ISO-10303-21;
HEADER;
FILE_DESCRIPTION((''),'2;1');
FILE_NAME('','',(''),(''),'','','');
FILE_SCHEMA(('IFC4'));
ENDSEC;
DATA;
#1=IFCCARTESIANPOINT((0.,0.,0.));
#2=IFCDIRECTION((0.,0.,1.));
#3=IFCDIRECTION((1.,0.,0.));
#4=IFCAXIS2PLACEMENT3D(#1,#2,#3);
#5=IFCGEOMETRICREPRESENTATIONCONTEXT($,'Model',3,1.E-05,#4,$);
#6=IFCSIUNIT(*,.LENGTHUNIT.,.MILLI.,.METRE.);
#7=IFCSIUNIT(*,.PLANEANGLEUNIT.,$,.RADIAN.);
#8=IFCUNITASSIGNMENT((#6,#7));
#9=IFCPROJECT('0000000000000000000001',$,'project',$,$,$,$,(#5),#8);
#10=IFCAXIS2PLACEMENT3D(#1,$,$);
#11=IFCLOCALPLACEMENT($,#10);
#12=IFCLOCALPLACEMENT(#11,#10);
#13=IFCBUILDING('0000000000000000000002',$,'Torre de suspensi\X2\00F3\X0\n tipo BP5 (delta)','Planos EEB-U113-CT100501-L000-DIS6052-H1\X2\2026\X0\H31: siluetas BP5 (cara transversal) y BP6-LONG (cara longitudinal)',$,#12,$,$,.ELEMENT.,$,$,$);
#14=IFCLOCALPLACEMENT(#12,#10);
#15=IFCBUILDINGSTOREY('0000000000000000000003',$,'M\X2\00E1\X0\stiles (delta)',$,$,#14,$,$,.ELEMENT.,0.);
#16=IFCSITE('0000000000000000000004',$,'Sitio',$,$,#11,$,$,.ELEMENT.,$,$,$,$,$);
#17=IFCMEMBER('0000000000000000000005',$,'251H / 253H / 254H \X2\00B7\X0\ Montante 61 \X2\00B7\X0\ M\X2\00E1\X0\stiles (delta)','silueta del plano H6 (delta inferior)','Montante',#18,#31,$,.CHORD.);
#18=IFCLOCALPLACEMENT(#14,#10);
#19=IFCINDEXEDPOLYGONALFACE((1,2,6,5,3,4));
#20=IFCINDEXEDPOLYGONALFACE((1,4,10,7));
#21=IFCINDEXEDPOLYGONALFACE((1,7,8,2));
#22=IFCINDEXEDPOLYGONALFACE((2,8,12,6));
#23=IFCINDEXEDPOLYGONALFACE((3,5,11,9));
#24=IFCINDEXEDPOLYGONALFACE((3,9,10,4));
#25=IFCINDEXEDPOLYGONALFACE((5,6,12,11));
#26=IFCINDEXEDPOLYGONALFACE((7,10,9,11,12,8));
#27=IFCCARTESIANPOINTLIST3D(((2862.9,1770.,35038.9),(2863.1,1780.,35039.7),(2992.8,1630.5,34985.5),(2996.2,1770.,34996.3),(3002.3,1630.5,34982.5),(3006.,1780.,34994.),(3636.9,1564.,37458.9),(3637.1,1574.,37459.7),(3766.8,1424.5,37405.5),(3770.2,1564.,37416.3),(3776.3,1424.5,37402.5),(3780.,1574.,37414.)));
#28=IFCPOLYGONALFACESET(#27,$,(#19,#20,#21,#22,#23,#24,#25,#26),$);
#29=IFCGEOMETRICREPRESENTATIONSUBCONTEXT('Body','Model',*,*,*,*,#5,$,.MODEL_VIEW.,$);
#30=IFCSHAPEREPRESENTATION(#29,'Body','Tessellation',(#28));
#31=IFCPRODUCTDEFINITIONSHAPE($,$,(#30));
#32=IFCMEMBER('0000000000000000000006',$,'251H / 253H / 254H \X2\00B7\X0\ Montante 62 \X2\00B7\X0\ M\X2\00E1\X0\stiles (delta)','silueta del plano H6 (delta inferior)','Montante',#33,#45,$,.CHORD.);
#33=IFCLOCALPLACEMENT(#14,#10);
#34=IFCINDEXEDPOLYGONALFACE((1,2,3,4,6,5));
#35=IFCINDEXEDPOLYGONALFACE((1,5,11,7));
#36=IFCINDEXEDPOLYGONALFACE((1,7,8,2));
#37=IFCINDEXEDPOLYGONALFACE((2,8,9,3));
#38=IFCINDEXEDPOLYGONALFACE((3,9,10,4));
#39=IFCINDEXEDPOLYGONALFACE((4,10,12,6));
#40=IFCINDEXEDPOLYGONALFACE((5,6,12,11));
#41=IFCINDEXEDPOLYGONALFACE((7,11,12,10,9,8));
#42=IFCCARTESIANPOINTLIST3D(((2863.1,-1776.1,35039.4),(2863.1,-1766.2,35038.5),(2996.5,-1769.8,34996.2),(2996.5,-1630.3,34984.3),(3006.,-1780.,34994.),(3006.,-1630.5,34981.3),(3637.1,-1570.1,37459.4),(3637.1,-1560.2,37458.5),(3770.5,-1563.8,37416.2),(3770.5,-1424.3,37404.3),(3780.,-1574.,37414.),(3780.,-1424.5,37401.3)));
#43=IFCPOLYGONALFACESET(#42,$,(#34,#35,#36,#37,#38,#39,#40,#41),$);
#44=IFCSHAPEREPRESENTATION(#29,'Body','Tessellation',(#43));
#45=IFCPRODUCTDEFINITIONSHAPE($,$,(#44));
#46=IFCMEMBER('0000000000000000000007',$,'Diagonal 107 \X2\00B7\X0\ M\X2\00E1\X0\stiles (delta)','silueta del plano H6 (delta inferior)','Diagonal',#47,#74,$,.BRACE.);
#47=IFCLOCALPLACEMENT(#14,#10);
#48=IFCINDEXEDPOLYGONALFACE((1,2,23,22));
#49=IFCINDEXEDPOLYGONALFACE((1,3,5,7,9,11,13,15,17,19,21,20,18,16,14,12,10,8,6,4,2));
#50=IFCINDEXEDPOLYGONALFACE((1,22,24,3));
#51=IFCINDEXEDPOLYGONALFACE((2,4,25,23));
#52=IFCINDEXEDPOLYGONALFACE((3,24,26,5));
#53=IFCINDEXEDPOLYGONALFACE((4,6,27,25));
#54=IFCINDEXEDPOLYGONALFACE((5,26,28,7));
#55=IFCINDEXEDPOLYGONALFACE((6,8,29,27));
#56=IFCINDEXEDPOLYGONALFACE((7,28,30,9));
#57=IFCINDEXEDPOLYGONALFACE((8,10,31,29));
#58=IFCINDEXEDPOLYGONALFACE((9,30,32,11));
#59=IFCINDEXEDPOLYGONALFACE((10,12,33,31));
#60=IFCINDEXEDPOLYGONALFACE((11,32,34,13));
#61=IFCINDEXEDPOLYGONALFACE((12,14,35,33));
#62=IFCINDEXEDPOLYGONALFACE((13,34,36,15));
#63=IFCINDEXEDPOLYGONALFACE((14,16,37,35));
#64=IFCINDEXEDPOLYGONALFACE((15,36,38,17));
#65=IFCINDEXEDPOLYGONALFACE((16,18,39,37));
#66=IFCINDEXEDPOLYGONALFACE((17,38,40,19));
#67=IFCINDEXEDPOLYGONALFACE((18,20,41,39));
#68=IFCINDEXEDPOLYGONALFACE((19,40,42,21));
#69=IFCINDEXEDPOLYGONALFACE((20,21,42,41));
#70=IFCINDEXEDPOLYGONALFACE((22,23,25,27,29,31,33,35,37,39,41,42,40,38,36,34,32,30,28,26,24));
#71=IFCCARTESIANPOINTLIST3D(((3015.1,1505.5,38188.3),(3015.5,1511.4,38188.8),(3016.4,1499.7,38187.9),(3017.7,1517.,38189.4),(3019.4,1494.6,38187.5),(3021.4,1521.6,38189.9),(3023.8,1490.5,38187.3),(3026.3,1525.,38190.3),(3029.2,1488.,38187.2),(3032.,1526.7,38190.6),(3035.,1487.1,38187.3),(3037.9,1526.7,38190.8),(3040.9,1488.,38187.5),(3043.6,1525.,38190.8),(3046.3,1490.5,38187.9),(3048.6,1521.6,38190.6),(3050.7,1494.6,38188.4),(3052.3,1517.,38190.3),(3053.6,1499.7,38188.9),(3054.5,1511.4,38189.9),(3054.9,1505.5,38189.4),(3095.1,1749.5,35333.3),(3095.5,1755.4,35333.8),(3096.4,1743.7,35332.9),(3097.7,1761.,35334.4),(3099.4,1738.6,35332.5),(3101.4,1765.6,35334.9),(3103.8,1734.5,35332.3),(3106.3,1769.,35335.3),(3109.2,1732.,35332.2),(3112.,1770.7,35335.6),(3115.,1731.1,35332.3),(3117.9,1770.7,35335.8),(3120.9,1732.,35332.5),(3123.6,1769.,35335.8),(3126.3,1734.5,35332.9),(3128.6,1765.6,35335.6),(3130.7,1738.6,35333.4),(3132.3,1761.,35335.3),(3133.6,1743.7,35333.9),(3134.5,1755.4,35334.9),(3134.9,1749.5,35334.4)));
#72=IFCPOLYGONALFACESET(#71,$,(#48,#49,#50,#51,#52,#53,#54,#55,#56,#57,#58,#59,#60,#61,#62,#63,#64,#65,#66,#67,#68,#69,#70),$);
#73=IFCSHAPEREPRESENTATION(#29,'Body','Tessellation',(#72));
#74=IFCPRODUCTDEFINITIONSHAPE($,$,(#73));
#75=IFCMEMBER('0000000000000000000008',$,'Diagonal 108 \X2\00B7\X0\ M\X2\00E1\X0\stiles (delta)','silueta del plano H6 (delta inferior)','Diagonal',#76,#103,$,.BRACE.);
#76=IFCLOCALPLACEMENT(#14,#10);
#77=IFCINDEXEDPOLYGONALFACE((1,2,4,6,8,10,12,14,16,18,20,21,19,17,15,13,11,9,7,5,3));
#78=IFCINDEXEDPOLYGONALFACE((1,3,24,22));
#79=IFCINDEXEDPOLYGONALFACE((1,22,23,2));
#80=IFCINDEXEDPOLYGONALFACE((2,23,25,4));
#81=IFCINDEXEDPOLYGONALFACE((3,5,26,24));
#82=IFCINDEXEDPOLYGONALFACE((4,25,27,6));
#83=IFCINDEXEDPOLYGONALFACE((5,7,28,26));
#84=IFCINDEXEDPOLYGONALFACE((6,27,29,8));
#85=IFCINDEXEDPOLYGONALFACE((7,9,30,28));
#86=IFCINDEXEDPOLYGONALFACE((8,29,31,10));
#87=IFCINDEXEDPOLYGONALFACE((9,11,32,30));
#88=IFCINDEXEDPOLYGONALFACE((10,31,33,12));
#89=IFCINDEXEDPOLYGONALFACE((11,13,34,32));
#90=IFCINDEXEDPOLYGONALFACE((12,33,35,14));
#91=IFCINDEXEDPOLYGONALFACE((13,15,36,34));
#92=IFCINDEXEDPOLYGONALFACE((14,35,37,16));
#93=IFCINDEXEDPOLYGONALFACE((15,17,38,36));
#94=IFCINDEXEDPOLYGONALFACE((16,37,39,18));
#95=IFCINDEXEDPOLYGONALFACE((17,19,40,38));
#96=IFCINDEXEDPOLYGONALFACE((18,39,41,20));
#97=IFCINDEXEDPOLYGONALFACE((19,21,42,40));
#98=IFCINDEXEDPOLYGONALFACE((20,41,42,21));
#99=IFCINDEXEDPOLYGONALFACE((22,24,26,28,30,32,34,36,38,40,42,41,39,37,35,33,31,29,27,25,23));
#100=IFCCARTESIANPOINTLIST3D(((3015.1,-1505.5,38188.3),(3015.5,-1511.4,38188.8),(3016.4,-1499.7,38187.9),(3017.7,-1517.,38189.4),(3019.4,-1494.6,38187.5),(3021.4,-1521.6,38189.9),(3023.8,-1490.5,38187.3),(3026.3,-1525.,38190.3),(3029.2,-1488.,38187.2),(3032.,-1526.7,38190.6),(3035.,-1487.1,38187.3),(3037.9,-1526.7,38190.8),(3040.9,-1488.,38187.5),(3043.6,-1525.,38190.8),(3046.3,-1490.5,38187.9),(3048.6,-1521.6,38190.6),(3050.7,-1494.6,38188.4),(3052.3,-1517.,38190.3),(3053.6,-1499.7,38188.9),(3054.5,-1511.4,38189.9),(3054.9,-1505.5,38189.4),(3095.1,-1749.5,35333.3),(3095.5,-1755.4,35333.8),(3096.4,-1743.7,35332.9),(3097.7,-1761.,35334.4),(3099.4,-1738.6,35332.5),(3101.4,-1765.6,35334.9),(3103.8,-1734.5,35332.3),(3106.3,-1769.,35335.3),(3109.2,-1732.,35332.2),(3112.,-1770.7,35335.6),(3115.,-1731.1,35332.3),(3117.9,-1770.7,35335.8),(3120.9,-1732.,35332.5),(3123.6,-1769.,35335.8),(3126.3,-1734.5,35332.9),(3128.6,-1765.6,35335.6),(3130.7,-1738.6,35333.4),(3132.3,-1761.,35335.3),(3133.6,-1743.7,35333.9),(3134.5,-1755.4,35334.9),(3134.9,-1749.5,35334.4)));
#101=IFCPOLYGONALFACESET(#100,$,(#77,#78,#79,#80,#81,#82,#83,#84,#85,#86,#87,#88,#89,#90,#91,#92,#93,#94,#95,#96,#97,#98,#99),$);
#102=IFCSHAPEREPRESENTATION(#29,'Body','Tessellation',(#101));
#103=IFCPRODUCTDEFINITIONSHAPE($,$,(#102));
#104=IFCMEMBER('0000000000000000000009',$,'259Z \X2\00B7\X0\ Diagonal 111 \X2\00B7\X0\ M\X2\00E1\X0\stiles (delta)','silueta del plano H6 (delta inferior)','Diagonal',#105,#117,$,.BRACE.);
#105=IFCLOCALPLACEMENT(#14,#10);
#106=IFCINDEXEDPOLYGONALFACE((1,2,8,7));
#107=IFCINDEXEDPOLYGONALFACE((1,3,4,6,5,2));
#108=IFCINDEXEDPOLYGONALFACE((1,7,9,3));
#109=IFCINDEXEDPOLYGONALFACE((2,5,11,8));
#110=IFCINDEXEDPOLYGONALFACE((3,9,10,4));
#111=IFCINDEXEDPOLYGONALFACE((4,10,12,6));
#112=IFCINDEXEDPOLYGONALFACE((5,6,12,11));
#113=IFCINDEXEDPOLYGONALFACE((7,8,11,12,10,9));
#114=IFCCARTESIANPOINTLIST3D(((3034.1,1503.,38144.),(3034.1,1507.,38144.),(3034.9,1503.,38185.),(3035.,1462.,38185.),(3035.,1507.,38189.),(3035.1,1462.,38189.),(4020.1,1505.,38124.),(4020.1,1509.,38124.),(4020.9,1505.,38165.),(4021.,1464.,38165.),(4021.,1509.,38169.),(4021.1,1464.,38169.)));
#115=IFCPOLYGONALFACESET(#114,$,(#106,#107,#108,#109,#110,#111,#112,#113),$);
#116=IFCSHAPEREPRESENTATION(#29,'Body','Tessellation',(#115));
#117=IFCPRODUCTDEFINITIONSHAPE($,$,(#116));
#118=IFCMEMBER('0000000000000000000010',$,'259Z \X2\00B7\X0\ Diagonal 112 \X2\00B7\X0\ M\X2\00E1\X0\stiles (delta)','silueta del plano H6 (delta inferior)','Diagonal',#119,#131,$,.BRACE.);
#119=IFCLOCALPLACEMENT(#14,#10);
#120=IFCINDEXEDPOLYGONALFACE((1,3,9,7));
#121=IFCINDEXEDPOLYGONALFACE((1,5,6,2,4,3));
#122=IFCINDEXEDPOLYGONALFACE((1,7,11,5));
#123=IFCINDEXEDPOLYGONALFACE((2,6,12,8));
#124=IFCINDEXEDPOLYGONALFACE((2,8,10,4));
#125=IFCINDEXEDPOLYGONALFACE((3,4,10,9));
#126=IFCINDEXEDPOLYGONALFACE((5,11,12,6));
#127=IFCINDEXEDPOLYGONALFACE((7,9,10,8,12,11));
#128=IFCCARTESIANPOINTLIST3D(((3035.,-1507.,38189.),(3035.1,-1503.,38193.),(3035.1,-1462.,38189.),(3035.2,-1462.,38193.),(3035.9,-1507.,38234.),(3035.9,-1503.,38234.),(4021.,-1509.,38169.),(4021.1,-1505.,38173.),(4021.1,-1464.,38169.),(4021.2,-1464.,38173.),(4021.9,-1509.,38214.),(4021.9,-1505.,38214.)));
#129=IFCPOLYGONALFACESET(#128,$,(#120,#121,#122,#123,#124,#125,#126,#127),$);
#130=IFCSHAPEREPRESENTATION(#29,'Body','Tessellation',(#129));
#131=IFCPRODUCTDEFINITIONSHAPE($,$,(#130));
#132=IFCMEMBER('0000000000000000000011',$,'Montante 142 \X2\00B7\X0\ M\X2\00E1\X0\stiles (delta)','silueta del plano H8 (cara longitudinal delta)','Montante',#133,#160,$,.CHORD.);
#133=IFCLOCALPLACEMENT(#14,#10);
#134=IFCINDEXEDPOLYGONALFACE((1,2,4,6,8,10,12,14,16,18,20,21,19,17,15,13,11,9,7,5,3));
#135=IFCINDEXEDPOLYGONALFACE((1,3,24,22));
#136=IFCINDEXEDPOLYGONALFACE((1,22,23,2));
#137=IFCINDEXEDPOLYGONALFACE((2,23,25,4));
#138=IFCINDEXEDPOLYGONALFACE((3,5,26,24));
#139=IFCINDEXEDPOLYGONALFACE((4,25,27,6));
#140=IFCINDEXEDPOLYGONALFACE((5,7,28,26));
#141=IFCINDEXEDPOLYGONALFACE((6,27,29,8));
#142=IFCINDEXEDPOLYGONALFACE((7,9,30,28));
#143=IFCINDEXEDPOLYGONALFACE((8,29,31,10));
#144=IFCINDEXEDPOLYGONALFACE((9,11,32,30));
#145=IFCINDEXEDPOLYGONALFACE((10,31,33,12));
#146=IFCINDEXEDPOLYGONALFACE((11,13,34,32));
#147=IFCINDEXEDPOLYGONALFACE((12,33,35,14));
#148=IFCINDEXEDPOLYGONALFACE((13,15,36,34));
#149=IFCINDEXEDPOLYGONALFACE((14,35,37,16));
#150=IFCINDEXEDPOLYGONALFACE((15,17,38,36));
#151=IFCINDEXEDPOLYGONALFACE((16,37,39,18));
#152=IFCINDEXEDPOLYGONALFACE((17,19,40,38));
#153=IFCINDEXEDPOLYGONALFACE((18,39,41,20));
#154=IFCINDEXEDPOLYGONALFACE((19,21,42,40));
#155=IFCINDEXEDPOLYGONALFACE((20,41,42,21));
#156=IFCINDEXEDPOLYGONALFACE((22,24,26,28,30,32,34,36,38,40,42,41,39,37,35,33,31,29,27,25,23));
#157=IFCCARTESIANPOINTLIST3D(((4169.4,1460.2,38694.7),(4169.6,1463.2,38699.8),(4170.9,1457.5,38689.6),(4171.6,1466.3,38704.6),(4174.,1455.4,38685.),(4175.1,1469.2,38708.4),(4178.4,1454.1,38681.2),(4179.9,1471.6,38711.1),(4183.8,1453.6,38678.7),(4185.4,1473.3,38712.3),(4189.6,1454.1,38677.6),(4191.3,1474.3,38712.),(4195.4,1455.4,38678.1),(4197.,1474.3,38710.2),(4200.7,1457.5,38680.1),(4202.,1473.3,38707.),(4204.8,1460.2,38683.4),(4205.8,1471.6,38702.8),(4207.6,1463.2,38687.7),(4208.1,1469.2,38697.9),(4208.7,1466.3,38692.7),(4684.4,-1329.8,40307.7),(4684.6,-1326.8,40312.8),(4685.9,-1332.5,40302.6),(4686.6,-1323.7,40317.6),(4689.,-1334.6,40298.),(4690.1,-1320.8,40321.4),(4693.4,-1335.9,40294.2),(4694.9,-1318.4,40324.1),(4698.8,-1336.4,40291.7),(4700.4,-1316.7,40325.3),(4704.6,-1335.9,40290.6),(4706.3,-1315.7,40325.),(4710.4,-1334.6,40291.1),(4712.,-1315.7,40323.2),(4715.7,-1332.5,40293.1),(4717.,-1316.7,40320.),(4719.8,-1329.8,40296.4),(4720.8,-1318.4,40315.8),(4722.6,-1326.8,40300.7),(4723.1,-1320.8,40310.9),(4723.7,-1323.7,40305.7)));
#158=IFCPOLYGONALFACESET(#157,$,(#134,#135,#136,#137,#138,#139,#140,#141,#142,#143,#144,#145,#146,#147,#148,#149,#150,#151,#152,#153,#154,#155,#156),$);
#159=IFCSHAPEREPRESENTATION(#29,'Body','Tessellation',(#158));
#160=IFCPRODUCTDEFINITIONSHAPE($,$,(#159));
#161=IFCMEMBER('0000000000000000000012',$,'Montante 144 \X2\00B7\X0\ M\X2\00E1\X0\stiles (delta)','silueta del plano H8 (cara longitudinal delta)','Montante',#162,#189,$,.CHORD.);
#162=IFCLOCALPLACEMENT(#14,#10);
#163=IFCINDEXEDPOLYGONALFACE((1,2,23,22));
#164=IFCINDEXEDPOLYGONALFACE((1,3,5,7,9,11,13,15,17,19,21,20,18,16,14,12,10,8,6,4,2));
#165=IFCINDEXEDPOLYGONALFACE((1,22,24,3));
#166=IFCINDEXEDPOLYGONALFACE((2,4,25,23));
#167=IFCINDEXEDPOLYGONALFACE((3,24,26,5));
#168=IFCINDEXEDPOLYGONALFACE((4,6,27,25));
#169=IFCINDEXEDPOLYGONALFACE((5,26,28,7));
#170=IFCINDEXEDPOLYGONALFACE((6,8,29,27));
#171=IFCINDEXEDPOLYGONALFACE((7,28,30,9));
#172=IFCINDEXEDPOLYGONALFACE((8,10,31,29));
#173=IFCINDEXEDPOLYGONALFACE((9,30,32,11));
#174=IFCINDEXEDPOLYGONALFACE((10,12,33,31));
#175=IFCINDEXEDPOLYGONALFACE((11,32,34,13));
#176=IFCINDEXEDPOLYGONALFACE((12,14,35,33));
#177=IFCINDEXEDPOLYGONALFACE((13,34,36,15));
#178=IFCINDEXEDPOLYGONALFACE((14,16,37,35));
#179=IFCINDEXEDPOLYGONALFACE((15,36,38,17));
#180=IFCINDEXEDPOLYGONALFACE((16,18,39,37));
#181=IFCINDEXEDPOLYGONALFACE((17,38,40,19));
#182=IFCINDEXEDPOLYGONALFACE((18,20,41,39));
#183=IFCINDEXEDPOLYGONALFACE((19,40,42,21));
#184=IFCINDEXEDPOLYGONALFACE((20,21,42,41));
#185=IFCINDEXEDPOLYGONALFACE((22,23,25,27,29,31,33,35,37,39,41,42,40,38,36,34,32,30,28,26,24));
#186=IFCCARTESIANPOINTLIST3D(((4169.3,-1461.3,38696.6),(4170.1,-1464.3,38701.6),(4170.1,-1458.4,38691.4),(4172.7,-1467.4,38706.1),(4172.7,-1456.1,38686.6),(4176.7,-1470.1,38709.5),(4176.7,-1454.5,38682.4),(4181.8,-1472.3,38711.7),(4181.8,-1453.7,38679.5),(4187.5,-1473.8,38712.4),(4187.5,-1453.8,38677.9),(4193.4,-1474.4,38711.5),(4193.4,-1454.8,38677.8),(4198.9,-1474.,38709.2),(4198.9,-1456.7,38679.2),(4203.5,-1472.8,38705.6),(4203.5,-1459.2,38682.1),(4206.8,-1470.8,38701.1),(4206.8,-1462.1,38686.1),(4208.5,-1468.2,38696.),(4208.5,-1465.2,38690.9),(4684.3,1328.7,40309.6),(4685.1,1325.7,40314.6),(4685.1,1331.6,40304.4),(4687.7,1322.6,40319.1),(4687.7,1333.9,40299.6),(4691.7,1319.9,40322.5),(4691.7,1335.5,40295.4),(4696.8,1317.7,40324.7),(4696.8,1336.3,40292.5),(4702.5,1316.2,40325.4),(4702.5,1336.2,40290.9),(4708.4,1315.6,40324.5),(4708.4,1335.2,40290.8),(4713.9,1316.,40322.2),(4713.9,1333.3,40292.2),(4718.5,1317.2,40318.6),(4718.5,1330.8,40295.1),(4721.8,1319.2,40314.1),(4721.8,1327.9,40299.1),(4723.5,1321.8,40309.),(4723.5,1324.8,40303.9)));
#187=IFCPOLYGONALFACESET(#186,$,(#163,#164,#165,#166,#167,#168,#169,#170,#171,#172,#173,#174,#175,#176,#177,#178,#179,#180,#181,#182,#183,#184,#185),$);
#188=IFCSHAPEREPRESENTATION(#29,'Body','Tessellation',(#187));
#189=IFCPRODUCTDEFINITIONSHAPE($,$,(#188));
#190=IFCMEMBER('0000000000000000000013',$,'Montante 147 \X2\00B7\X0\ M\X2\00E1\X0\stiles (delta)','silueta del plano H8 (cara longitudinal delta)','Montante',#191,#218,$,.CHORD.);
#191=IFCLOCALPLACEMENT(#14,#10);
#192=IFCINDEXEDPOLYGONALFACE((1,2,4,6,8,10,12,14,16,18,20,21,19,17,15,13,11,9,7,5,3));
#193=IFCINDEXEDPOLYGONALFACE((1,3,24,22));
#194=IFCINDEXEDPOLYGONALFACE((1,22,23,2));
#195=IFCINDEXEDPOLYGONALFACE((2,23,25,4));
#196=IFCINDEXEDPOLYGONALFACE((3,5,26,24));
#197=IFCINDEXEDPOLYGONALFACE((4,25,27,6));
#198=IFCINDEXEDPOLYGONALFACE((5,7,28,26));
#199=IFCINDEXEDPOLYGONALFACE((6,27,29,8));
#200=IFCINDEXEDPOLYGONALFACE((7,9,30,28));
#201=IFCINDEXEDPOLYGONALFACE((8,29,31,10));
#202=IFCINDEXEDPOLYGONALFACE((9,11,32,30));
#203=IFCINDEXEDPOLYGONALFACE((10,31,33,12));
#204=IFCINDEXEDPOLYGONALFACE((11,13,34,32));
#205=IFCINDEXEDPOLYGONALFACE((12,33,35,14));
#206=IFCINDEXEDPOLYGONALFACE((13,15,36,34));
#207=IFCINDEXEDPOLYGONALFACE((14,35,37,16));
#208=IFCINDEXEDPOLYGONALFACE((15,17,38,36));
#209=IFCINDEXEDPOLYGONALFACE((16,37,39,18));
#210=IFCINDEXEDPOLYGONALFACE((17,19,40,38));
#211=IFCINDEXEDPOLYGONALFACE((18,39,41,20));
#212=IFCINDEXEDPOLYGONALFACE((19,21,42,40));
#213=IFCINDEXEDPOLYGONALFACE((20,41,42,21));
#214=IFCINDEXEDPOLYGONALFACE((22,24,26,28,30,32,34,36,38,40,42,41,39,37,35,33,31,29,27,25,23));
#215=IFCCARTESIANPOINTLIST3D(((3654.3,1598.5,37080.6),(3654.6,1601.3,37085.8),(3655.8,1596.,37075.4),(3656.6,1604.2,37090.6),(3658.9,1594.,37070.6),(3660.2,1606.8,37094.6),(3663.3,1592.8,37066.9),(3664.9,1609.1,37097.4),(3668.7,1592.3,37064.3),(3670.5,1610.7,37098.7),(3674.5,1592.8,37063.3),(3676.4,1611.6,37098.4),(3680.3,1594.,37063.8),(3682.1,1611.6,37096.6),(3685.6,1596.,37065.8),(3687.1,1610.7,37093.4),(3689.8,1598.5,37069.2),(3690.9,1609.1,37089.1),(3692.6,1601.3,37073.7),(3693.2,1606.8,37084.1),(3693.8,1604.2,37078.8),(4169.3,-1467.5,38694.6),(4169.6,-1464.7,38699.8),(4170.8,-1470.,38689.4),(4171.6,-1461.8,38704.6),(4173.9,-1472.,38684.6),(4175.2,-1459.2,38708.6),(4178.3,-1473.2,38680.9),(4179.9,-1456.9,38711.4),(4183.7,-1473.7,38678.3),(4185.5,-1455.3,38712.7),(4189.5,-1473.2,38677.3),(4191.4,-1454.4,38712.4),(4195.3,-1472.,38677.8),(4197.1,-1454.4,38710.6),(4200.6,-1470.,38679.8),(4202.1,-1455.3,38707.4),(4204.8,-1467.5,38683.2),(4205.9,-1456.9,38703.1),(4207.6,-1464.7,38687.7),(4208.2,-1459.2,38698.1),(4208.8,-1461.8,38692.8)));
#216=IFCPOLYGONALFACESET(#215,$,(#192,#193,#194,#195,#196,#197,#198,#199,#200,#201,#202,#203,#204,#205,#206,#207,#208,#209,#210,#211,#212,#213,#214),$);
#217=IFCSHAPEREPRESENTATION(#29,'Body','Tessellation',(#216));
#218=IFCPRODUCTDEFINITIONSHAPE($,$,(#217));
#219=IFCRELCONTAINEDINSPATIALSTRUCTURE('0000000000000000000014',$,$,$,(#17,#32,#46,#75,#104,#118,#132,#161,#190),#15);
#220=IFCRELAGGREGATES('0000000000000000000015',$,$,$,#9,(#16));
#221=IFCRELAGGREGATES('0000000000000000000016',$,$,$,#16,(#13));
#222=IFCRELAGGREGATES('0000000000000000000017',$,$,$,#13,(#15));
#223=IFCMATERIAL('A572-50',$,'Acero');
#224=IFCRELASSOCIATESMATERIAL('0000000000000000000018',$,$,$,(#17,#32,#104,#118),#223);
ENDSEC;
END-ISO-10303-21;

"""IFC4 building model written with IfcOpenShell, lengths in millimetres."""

from ifc_helpers import new_model, si_unit, frame, frame_2d, origin, origin_with_axes, place, context, subcontext, project, spatial, circle, l_section, extrude, material, element, save


model = new_model("IFC4")

# Units and contexts
model_context = context("Model", 3, precision=1e-05, world=origin_with_axes())
body_context = subcontext(model_context, "Body", "Model", "MODEL_VIEW")
ifc_project = project(units=[si_unit("LENGTHUNIT", "METRE", prefix="MILLI"), si_unit("PLANEANGLEUNIT", "RADIAN")], contexts=[model_context])

# Site, building, storey
site_placement = place(None, origin())
site = spatial("IfcSite", under=ifc_project, at=site_placement, Name="Sitio", CompositionType="ELEMENT")
building_placement = place(site_placement, origin())
building = spatial("IfcBuilding", under=site, at=building_placement, Name="Torre de suspensión tipo BP5 (delta)", Description="Planos EEB-U113-CT100501-L000-DIS6052-H1…H31: siluetas BP5 (cara transversal) y BP6-LONG (cara longitudinal)", CompositionType="ELEMENT")
storey_placement = place(building_placement, origin())
storey = spatial("IfcBuildingStorey", under=building, at=storey_placement, Name="Mástiles (delta)", CompositionType="ELEMENT", Elevation=0.0)

# Members
ifc_material = material(Name="A572-50", Category="Acero")
for number, where, z_axis, x_axis, name in (
    (1, (3780.0, 1574.0, 37414.0), (-0.303637, 0.080813, -0.949355), (-0.024618, -0.996729, -0.076972), "251H / 253H / 254H · Montante 61 · Mástiles (delta)"),
    (2, (3780.0, -1574.0, 37414.0), (-0.303637, -0.080813, -0.949355), (-0.952788, 0.025754, 0.302542), "251H / 253H / 254H · Montante 62 · Mástiles (delta)"),
):
    element("IfcMember", number, at=place(storey_placement, frame(where, z_axis=z_axis, x_axis=x_axis)), inside=storey, material=ifc_material, Name=name, Description="silueta del plano H6 (delta inferior)", ObjectType="Montante", PredefinedType="CHORD", context=body_context, shape_type="SweptSolid", body=[
        extrude(l_section(Depth=150.0, Width=150.0, Thickness=10.0, at=frame_2d((75.0, 75.0))), None, (0.0, 0.0, 1.0), 2549.1),
    ])
for number, where, z_axis, x_axis, name in (
    (3, (3035.0, 1507.0, 38189.0), (0.027908, 0.085121, -0.99598), (0.002384, -0.996371, -0.085087), "Diagonal 107 · Mástiles (delta)"),
    (4, (3035.0, -1507.0, 38189.0), (0.027908, -0.085121, -0.99598), (0.002384, 0.996371, -0.085087), "Diagonal 108 · Mástiles (delta)"),
):
    element("IfcMember", number, at=place(storey_placement, frame(where, z_axis=z_axis, x_axis=x_axis)), inside=storey, Name=name, Description="silueta del plano H6 (delta inferior)", ObjectType="Diagonal", PredefinedType="BRACE", context=body_context, shape_type="SweptSolid", body=[
        extrude(circle(Radius=20.0), None, (0.0, 0.0, 1.0), 2866.5),
    ])
for number, where, z_axis, x_axis, name in (
    (5, (3035.0, 1507.0, 38189.0), (0.999792, 0.002028, -0.02028), (0.002028, -0.999998, -0.000041), "259Z · Diagonal 111 · Mástiles (delta)"),
    (6, (3035.0, -1507.0, 38189.0), (0.999792, -0.002028, -0.02028), (0.002028, 0.999998, -0.000041), "259Z · Diagonal 112 · Mástiles (delta)"),
):
    element("IfcMember", number, at=place(storey_placement, frame(where, z_axis=z_axis, x_axis=x_axis)), inside=storey, material=ifc_material, Name=name, Description="silueta del plano H6 (delta inferior)", ObjectType="Diagonal", PredefinedType="BRACE", context=body_context, shape_type="SweptSolid", body=[
        extrude(l_section(Depth=45.0, Width=45.0, Thickness=4.0, at=frame_2d((22.5, 22.5))), None, (0.0, 0.0, 1.0), 986.2),
    ])
for number, where, z_axis, x_axis, name in (
    (7, (4704.0, -1326.0, 40308.0), (-0.157801, 0.854884, -0.494239), (-0.260017, -0.518819, -0.814382), "Montante 142 · Mástiles (delta)"),
    (8, (4704.0, 1326.0, 40308.0), (-0.157801, -0.854884, -0.494239), (-0.987471, 0.136613, 0.078981), "Montante 144 · Mástiles (delta)"),
):
    element("IfcMember", number, at=place(storey_placement, frame(where, z_axis=z_axis, x_axis=x_axis)), inside=storey, Name=name, Description="silueta del plano H8 (cara longitudinal delta)", ObjectType="Montante", PredefinedType="CHORD", context=body_context, shape_type="SweptSolid", body=[
        extrude(circle(Radius=20.0), None, (0.0, 0.0, 1.0), 3263.6),
    ])
member_1_placement = place(storey_placement, frame((4189.0, -1464.0, 38695.0), z_axis=(-0.147019, 0.875265, -0.460756), x_axis=(-0.266066, -0.483643, -0.833845)))
element("IfcMember", 9, at=member_1_placement, inside=storey, Name="Montante 147 · Mástiles (delta)", Description="silueta del plano H8 (cara longitudinal delta)", ObjectType="Montante", PredefinedType="CHORD", context=body_context, shape_type="SweptSolid", body=[
    extrude(circle(Radius=20.0), None, (0.0, 0.0, 1.0), 3502.9),
])

save(model, "model.ifc")
